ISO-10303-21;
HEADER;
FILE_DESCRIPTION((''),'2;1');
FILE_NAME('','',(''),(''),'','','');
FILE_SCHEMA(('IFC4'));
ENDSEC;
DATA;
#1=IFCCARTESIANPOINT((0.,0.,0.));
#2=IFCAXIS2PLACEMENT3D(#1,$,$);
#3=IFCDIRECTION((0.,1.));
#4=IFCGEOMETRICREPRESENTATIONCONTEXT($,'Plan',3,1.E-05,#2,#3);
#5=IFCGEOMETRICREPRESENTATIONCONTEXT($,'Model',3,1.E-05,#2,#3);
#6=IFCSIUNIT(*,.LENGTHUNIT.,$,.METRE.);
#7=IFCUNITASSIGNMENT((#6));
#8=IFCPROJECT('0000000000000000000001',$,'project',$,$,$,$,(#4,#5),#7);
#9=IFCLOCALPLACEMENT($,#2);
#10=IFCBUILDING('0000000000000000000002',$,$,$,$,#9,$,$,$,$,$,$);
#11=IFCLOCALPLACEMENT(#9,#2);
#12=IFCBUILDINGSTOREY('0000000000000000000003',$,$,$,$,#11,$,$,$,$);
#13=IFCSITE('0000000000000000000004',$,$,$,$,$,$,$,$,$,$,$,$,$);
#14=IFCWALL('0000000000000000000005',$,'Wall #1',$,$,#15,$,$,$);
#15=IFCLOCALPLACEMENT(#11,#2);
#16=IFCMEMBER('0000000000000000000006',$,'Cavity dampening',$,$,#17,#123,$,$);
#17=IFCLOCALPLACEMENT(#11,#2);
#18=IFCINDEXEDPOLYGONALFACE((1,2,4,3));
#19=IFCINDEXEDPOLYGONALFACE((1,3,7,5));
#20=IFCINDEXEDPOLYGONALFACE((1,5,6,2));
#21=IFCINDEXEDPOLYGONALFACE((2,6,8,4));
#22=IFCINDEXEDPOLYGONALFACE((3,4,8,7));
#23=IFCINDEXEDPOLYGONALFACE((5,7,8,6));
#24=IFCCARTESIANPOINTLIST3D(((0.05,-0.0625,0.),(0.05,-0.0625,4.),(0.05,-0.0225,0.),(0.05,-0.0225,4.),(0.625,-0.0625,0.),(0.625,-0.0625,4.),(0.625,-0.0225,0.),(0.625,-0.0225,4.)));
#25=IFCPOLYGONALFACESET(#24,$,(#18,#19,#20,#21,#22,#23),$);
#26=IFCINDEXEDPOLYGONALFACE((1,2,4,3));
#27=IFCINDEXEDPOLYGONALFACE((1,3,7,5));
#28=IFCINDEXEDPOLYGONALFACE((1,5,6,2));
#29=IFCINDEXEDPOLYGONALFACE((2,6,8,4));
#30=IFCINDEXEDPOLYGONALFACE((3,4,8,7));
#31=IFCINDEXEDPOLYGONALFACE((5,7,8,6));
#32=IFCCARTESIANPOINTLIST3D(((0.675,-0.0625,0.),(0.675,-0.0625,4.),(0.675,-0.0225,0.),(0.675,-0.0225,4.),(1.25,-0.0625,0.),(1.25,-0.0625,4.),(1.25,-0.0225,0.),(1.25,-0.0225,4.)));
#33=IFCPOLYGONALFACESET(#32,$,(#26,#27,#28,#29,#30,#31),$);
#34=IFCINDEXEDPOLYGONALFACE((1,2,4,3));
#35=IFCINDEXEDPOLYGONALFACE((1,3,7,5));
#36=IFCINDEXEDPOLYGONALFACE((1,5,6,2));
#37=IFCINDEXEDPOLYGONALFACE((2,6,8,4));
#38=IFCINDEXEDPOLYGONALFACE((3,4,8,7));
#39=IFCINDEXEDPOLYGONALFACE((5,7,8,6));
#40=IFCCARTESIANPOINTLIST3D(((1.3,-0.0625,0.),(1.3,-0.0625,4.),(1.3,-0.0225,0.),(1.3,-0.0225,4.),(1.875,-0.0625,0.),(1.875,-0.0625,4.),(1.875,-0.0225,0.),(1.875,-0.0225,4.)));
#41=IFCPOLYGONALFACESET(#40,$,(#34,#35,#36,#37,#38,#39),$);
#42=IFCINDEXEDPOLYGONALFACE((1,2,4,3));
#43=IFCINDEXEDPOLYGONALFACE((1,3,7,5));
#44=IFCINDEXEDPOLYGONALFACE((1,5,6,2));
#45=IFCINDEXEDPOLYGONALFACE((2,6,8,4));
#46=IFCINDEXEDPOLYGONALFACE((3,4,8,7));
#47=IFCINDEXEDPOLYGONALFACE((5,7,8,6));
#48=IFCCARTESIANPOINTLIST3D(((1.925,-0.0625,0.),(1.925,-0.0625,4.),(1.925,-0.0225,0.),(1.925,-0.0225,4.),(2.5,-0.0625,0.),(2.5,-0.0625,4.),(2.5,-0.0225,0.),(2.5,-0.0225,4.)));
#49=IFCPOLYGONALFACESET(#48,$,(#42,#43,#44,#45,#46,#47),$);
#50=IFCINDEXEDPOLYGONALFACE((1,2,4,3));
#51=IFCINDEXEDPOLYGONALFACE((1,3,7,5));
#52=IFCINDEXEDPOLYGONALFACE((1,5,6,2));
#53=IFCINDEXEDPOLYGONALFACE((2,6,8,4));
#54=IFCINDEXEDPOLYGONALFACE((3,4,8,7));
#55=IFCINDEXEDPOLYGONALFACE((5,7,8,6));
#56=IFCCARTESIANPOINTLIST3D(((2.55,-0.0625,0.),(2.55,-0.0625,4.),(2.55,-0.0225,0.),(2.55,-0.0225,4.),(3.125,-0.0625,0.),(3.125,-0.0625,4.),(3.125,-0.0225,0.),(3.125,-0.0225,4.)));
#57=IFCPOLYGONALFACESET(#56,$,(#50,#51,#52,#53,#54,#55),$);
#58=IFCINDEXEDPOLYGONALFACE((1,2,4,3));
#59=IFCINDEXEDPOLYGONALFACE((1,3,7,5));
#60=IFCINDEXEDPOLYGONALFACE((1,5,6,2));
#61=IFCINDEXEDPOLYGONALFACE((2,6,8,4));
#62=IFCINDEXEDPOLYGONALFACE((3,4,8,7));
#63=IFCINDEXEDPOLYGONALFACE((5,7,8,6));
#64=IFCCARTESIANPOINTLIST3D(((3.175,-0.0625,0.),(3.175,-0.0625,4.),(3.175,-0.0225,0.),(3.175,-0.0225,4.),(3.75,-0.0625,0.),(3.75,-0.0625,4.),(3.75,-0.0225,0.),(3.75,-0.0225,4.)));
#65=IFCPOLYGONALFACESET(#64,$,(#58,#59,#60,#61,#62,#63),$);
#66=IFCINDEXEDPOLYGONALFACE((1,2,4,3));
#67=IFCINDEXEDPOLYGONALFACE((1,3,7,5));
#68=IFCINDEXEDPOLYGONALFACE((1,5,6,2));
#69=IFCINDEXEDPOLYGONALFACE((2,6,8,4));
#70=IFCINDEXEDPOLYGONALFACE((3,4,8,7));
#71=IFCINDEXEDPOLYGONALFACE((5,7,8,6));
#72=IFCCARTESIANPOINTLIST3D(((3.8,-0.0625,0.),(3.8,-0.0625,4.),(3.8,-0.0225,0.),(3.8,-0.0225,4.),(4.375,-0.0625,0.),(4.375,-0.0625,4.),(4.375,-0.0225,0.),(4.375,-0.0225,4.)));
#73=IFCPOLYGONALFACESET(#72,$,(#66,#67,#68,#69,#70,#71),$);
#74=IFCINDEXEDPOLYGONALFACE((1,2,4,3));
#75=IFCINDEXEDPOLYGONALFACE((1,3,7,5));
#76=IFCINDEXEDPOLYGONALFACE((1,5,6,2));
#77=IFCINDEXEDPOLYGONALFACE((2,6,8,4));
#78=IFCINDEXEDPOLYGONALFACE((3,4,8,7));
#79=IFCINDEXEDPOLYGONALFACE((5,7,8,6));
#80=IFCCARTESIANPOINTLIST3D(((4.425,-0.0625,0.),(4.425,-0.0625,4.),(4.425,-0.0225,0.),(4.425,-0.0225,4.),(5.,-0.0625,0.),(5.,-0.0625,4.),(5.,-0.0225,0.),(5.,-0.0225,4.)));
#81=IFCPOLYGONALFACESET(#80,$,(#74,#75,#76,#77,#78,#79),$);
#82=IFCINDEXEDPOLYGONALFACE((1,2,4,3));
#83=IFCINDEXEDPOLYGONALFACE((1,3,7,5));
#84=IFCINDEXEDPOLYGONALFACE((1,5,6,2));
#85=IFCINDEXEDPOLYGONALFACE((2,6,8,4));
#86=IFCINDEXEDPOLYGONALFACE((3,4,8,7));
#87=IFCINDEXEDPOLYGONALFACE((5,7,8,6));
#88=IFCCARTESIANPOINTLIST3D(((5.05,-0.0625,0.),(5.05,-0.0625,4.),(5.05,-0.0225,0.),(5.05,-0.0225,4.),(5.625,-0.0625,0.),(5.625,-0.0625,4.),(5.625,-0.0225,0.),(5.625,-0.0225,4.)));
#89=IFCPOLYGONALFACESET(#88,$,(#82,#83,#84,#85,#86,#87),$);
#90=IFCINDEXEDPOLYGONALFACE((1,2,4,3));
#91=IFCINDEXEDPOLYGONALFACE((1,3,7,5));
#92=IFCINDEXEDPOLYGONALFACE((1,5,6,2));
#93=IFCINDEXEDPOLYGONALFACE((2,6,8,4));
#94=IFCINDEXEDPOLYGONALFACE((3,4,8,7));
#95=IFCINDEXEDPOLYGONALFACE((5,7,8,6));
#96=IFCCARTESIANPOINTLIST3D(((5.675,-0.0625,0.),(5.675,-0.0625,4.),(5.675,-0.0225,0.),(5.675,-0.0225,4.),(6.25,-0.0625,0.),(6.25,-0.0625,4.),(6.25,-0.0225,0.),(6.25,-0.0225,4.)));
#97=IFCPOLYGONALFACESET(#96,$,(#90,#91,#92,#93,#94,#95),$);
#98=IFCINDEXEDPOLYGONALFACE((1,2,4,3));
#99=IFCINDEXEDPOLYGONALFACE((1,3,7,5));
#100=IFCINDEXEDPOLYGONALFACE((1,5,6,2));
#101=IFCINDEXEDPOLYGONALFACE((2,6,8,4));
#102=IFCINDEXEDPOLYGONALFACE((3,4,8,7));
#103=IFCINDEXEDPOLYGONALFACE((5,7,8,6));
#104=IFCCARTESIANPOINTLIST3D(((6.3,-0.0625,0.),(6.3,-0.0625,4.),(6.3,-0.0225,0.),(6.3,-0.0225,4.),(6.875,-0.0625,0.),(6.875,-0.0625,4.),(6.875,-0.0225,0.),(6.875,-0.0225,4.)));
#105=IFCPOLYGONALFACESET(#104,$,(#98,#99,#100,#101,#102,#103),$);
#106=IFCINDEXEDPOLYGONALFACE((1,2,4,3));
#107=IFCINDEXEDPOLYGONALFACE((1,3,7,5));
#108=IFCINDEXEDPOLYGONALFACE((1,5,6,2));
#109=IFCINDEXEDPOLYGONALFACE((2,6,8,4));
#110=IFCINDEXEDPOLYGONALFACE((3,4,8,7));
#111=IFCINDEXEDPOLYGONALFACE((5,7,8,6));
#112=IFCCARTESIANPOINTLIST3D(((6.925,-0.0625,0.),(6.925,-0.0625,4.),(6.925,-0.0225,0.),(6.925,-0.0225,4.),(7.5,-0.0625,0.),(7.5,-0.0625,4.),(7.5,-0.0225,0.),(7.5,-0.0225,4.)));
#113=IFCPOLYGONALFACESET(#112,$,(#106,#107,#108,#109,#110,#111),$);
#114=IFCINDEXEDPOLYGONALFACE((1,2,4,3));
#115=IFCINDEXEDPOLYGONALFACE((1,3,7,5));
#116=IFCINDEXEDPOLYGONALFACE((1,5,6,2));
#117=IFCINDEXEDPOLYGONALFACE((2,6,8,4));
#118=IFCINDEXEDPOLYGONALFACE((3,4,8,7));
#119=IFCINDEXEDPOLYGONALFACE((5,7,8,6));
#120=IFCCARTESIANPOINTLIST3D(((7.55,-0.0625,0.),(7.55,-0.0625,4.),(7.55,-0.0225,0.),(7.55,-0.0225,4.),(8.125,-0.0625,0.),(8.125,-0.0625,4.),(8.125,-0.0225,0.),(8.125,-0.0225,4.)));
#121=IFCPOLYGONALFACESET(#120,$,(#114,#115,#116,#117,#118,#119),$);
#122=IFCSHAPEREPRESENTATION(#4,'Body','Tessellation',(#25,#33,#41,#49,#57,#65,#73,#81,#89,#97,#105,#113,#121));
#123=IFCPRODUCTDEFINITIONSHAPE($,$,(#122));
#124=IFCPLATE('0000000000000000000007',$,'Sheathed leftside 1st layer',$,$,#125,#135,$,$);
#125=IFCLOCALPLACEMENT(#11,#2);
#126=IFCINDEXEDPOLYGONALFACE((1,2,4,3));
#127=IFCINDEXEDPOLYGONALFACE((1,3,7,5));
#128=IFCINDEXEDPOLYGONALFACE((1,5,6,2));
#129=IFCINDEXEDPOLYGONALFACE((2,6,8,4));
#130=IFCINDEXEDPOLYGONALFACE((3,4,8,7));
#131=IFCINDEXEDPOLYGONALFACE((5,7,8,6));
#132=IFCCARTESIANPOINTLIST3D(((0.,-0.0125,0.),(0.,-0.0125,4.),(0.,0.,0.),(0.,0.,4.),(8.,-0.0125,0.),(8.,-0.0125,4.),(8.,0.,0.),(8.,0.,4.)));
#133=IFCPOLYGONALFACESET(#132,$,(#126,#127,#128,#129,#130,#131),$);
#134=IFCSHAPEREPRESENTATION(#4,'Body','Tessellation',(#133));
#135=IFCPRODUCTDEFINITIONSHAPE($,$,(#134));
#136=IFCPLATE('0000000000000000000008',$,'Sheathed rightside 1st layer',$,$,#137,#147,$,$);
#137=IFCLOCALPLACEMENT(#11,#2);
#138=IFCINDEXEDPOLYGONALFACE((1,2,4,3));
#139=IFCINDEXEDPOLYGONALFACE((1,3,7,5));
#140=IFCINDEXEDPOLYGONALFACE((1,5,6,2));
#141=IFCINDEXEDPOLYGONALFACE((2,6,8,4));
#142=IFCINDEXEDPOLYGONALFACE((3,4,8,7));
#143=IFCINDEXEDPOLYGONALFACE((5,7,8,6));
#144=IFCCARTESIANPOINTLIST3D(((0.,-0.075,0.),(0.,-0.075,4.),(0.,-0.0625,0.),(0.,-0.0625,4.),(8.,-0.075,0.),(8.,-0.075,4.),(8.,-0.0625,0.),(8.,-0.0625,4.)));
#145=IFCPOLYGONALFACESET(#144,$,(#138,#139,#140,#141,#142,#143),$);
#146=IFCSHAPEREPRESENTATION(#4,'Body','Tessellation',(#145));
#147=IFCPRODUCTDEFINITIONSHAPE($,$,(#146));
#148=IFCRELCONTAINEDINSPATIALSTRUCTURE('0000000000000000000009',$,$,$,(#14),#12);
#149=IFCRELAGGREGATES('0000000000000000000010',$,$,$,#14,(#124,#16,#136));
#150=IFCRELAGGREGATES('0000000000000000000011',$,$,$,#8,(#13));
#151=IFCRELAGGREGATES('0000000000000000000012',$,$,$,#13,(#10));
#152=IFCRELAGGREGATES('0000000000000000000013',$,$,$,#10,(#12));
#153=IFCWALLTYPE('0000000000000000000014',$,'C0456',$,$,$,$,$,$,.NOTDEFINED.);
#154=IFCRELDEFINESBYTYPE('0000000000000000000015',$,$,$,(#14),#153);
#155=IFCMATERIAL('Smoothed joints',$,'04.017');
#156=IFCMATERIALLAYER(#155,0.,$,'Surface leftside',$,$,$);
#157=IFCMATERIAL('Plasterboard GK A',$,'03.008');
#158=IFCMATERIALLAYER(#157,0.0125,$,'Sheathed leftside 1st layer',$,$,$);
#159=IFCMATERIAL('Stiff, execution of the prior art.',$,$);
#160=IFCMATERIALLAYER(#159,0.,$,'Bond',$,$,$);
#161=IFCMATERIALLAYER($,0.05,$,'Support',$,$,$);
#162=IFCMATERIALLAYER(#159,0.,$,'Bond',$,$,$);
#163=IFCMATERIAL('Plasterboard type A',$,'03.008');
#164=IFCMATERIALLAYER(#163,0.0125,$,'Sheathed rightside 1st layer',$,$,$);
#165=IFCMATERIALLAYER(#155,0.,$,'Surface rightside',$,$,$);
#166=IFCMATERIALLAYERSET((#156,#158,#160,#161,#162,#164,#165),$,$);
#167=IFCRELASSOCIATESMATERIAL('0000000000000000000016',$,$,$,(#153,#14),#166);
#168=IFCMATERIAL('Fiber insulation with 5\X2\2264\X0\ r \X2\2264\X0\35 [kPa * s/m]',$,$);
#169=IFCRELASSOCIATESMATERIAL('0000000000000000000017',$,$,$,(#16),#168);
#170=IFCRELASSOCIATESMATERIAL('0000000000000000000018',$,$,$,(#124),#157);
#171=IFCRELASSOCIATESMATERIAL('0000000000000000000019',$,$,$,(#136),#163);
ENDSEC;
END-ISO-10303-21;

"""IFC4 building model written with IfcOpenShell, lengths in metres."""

from ifc_helpers import new_model, si_unit, direction, frame, frame_2d, origin, origin_with_axes, place, context, project, spatial, rectangle, extrude, material, layer, layer_set, type_object, element, aggregate, save


model = new_model("IFC4")

# Units and contexts
plan_context = context("Plan", 3, precision=1e-05, world=origin(), true_north=direction((0.0, 1.0)))
model_context = context("Model", 3, precision=1e-05, world=origin(), true_north=direction((0.0, 1.0)))
ifc_project = project(units=[si_unit("LENGTHUNIT", "METRE")], contexts=[plan_context, model_context])

# Site, building, storey
site = spatial("IfcSite", under=ifc_project)
building_placement = place(None, origin())
building = spatial("IfcBuilding", under=site, at=building_placement)
storey_placement = place(building_placement, origin())
storey = spatial("IfcBuildingStorey", under=building, at=storey_placement)

# Wall, member, plates
ifc_material_1 = material(Name="Smoothed joints", Category="04.017")
ifc_layer_1 = layer(ifc_material_1, 0.0, Name="Surface leftside")
ifc_material_2 = material(Name="Plasterboard GK A", Category="03.008")
ifc_layer_2 = layer(ifc_material_2, 0.0125, Name="Sheathed leftside 1st layer")
ifc_material_3 = material(Name="Stiff, execution of the prior art.")
ifc_layer_3 = layer(ifc_material_3, 0.0, Name="Bond")
ifc_layer_4 = layer(None, 0.05, Name="Support")
ifc_layer_5 = layer(ifc_material_3, 0.0, Name="Bond")
ifc_material_4 = material(Name="Plasterboard type A", Category="03.008")
ifc_layer_6 = layer(ifc_material_4, 0.0125, Name="Sheathed rightside 1st layer")
ifc_layer_7 = layer(ifc_material_1, 0.0, Name="Surface rightside")
ifc_layer_set = layer_set([ifc_layer_1, ifc_layer_2, ifc_layer_3, ifc_layer_4, ifc_layer_5, ifc_layer_6, ifc_layer_7])
wall_type = type_object("IfcWallType", Name="C0456", PredefinedType="NOTDEFINED", material=ifc_layer_set)
wall_placement = place(None, frame((0.0, 0.0, 0.0), z_axis=(0.0, -1.0, 0.0), x_axis=(1.0, 0.0, 0.0)))
wall = element("IfcWall", 1, at=wall_placement, inside=storey, type_object=wall_type, material=ifc_layer_set, Name="Wall #1")
ifc_material_5 = material(Name="Fiber insulation with 5≤ r ≤35 [kPa * s/m]")
member_1_placement = place(wall_placement, origin())
member_1 = element("IfcMember", 2, at=member_1_placement, material=ifc_material_5, Name="Cavity dampening", context=plan_context, shape_type="SweptSolid", body=[
    extrude(rectangle(XDim=0.575, YDim=0.04, at=frame_2d((0.2875, 0.02), x_axis=(1.0, 0.0))), frame((0.05, 4.0, 0.0225), z_axis=(0.0, -1.0, 0.0), x_axis=(1.0, 0.0, 0.0)), (0.0, 0.0, 1.0), 4.0),
    extrude(rectangle(XDim=0.575, YDim=0.04, at=frame_2d((0.2875, 0.02), x_axis=(1.0, 0.0))), frame((0.675, 4.0, 0.0225), z_axis=(0.0, -1.0, 0.0), x_axis=(1.0, 0.0, 0.0)), (0.0, 0.0, 1.0), 4.0),
    extrude(rectangle(XDim=0.575, YDim=0.04, at=frame_2d((0.2875, 0.02), x_axis=(1.0, 0.0))), frame((1.3, 4.0, 0.0225), z_axis=(0.0, -1.0, 0.0), x_axis=(1.0, 0.0, 0.0)), (0.0, 0.0, 1.0), 4.0),
    extrude(rectangle(XDim=0.575, YDim=0.04, at=frame_2d((0.2875, 0.02), x_axis=(1.0, 0.0))), frame((1.925, 4.0, 0.0225), z_axis=(0.0, -1.0, 0.0), x_axis=(1.0, 0.0, 0.0)), (0.0, 0.0, 1.0), 4.0),
    extrude(rectangle(XDim=0.575, YDim=0.04, at=frame_2d((0.2875, 0.02), x_axis=(1.0, 0.0))), frame((2.55, 4.0, 0.0225), z_axis=(0.0, -1.0, 0.0), x_axis=(1.0, 0.0, 0.0)), (0.0, 0.0, 1.0), 4.0),
    extrude(rectangle(XDim=0.575, YDim=0.04, at=frame_2d((0.2875, 0.02), x_axis=(1.0, 0.0))), frame((3.175, 4.0, 0.0225), z_axis=(0.0, -1.0, 0.0), x_axis=(1.0, 0.0, 0.0)), (0.0, 0.0, 1.0), 4.0),
    extrude(rectangle(XDim=0.575, YDim=0.04, at=frame_2d((0.2875, 0.02), x_axis=(1.0, 0.0))), frame((3.8, 4.0, 0.0225), z_axis=(0.0, -1.0, 0.0), x_axis=(1.0, 0.0, 0.0)), (0.0, 0.0, 1.0), 4.0),
    extrude(rectangle(XDim=0.575, YDim=0.04, at=frame_2d((0.2875, 0.02), x_axis=(1.0, 0.0))), frame((4.425, 4.0, 0.0225), z_axis=(0.0, -1.0, 0.0), x_axis=(1.0, 0.0, 0.0)), (0.0, 0.0, 1.0), 4.0),
    extrude(rectangle(XDim=0.575, YDim=0.04, at=frame_2d((0.2875, 0.02), x_axis=(1.0, 0.0))), frame((5.05, 4.0, 0.0225), z_axis=(0.0, -1.0, 0.0), x_axis=(1.0, 0.0, 0.0)), (0.0, 0.0, 1.0), 4.0),
    extrude(rectangle(XDim=0.575, YDim=0.04, at=frame_2d((0.2875, 0.02), x_axis=(1.0, 0.0))), frame((5.675, 4.0, 0.0225), z_axis=(0.0, -1.0, 0.0), x_axis=(1.0, 0.0, 0.0)), (0.0, 0.0, 1.0), 4.0),
    extrude(rectangle(XDim=0.575, YDim=0.04, at=frame_2d((0.2875, 0.02), x_axis=(1.0, 0.0))), frame((6.3, 4.0, 0.0225), z_axis=(0.0, -1.0, 0.0), x_axis=(1.0, 0.0, 0.0)), (0.0, 0.0, 1.0), 4.0),
    extrude(rectangle(XDim=0.575, YDim=0.04, at=frame_2d((0.2875, 0.02), x_axis=(1.0, 0.0))), frame((6.925, 4.0, 0.0225), z_axis=(0.0, -1.0, 0.0), x_axis=(1.0, 0.0, 0.0)), (0.0, 0.0, 1.0), 4.0),
    extrude(rectangle(XDim=0.575, YDim=0.04, at=frame_2d((0.2875, 0.02), x_axis=(1.0, 0.0))), frame((7.55, 4.0, 0.0225), z_axis=(0.0, -1.0, 0.0), x_axis=(1.0, 0.0, 0.0)), (0.0, 0.0, 1.0), 4.0),
])
plate_1_placement = place(wall_placement, origin())
plate_1 = element("IfcPlate", 3, at=plate_1_placement, material=ifc_material_2, Name="Sheathed leftside 1st layer", context=plan_context, shape_type="SweptSolid", body=[
    extrude(rectangle(XDim=8.0, YDim=4.0, at=frame_2d((4.0, 2.0), x_axis=(1.0, 0.0))), origin_with_axes(), (0.0, 0.0, 1.0), 0.0125),
])
plate_2_placement = place(wall_placement, origin())
plate_2 = element("IfcPlate", 4, at=plate_2_placement, material=ifc_material_4, Name="Sheathed rightside 1st layer", context=plan_context, shape_type="SweptSolid", body=[
    extrude(rectangle(XDim=8.0, YDim=4.0, at=frame_2d((4.0, 2.0), x_axis=(1.0, 0.0))), frame((0.0, 0.0, 0.0625), z_axis=(0.0, 0.0, 1.0), x_axis=(1.0, 0.0, 0.0)), (0.0, 0.0, 1.0), 0.0125),
])
aggregate(wall, [plate_1, member_1, plate_2])

save(model, "model.ifc")
